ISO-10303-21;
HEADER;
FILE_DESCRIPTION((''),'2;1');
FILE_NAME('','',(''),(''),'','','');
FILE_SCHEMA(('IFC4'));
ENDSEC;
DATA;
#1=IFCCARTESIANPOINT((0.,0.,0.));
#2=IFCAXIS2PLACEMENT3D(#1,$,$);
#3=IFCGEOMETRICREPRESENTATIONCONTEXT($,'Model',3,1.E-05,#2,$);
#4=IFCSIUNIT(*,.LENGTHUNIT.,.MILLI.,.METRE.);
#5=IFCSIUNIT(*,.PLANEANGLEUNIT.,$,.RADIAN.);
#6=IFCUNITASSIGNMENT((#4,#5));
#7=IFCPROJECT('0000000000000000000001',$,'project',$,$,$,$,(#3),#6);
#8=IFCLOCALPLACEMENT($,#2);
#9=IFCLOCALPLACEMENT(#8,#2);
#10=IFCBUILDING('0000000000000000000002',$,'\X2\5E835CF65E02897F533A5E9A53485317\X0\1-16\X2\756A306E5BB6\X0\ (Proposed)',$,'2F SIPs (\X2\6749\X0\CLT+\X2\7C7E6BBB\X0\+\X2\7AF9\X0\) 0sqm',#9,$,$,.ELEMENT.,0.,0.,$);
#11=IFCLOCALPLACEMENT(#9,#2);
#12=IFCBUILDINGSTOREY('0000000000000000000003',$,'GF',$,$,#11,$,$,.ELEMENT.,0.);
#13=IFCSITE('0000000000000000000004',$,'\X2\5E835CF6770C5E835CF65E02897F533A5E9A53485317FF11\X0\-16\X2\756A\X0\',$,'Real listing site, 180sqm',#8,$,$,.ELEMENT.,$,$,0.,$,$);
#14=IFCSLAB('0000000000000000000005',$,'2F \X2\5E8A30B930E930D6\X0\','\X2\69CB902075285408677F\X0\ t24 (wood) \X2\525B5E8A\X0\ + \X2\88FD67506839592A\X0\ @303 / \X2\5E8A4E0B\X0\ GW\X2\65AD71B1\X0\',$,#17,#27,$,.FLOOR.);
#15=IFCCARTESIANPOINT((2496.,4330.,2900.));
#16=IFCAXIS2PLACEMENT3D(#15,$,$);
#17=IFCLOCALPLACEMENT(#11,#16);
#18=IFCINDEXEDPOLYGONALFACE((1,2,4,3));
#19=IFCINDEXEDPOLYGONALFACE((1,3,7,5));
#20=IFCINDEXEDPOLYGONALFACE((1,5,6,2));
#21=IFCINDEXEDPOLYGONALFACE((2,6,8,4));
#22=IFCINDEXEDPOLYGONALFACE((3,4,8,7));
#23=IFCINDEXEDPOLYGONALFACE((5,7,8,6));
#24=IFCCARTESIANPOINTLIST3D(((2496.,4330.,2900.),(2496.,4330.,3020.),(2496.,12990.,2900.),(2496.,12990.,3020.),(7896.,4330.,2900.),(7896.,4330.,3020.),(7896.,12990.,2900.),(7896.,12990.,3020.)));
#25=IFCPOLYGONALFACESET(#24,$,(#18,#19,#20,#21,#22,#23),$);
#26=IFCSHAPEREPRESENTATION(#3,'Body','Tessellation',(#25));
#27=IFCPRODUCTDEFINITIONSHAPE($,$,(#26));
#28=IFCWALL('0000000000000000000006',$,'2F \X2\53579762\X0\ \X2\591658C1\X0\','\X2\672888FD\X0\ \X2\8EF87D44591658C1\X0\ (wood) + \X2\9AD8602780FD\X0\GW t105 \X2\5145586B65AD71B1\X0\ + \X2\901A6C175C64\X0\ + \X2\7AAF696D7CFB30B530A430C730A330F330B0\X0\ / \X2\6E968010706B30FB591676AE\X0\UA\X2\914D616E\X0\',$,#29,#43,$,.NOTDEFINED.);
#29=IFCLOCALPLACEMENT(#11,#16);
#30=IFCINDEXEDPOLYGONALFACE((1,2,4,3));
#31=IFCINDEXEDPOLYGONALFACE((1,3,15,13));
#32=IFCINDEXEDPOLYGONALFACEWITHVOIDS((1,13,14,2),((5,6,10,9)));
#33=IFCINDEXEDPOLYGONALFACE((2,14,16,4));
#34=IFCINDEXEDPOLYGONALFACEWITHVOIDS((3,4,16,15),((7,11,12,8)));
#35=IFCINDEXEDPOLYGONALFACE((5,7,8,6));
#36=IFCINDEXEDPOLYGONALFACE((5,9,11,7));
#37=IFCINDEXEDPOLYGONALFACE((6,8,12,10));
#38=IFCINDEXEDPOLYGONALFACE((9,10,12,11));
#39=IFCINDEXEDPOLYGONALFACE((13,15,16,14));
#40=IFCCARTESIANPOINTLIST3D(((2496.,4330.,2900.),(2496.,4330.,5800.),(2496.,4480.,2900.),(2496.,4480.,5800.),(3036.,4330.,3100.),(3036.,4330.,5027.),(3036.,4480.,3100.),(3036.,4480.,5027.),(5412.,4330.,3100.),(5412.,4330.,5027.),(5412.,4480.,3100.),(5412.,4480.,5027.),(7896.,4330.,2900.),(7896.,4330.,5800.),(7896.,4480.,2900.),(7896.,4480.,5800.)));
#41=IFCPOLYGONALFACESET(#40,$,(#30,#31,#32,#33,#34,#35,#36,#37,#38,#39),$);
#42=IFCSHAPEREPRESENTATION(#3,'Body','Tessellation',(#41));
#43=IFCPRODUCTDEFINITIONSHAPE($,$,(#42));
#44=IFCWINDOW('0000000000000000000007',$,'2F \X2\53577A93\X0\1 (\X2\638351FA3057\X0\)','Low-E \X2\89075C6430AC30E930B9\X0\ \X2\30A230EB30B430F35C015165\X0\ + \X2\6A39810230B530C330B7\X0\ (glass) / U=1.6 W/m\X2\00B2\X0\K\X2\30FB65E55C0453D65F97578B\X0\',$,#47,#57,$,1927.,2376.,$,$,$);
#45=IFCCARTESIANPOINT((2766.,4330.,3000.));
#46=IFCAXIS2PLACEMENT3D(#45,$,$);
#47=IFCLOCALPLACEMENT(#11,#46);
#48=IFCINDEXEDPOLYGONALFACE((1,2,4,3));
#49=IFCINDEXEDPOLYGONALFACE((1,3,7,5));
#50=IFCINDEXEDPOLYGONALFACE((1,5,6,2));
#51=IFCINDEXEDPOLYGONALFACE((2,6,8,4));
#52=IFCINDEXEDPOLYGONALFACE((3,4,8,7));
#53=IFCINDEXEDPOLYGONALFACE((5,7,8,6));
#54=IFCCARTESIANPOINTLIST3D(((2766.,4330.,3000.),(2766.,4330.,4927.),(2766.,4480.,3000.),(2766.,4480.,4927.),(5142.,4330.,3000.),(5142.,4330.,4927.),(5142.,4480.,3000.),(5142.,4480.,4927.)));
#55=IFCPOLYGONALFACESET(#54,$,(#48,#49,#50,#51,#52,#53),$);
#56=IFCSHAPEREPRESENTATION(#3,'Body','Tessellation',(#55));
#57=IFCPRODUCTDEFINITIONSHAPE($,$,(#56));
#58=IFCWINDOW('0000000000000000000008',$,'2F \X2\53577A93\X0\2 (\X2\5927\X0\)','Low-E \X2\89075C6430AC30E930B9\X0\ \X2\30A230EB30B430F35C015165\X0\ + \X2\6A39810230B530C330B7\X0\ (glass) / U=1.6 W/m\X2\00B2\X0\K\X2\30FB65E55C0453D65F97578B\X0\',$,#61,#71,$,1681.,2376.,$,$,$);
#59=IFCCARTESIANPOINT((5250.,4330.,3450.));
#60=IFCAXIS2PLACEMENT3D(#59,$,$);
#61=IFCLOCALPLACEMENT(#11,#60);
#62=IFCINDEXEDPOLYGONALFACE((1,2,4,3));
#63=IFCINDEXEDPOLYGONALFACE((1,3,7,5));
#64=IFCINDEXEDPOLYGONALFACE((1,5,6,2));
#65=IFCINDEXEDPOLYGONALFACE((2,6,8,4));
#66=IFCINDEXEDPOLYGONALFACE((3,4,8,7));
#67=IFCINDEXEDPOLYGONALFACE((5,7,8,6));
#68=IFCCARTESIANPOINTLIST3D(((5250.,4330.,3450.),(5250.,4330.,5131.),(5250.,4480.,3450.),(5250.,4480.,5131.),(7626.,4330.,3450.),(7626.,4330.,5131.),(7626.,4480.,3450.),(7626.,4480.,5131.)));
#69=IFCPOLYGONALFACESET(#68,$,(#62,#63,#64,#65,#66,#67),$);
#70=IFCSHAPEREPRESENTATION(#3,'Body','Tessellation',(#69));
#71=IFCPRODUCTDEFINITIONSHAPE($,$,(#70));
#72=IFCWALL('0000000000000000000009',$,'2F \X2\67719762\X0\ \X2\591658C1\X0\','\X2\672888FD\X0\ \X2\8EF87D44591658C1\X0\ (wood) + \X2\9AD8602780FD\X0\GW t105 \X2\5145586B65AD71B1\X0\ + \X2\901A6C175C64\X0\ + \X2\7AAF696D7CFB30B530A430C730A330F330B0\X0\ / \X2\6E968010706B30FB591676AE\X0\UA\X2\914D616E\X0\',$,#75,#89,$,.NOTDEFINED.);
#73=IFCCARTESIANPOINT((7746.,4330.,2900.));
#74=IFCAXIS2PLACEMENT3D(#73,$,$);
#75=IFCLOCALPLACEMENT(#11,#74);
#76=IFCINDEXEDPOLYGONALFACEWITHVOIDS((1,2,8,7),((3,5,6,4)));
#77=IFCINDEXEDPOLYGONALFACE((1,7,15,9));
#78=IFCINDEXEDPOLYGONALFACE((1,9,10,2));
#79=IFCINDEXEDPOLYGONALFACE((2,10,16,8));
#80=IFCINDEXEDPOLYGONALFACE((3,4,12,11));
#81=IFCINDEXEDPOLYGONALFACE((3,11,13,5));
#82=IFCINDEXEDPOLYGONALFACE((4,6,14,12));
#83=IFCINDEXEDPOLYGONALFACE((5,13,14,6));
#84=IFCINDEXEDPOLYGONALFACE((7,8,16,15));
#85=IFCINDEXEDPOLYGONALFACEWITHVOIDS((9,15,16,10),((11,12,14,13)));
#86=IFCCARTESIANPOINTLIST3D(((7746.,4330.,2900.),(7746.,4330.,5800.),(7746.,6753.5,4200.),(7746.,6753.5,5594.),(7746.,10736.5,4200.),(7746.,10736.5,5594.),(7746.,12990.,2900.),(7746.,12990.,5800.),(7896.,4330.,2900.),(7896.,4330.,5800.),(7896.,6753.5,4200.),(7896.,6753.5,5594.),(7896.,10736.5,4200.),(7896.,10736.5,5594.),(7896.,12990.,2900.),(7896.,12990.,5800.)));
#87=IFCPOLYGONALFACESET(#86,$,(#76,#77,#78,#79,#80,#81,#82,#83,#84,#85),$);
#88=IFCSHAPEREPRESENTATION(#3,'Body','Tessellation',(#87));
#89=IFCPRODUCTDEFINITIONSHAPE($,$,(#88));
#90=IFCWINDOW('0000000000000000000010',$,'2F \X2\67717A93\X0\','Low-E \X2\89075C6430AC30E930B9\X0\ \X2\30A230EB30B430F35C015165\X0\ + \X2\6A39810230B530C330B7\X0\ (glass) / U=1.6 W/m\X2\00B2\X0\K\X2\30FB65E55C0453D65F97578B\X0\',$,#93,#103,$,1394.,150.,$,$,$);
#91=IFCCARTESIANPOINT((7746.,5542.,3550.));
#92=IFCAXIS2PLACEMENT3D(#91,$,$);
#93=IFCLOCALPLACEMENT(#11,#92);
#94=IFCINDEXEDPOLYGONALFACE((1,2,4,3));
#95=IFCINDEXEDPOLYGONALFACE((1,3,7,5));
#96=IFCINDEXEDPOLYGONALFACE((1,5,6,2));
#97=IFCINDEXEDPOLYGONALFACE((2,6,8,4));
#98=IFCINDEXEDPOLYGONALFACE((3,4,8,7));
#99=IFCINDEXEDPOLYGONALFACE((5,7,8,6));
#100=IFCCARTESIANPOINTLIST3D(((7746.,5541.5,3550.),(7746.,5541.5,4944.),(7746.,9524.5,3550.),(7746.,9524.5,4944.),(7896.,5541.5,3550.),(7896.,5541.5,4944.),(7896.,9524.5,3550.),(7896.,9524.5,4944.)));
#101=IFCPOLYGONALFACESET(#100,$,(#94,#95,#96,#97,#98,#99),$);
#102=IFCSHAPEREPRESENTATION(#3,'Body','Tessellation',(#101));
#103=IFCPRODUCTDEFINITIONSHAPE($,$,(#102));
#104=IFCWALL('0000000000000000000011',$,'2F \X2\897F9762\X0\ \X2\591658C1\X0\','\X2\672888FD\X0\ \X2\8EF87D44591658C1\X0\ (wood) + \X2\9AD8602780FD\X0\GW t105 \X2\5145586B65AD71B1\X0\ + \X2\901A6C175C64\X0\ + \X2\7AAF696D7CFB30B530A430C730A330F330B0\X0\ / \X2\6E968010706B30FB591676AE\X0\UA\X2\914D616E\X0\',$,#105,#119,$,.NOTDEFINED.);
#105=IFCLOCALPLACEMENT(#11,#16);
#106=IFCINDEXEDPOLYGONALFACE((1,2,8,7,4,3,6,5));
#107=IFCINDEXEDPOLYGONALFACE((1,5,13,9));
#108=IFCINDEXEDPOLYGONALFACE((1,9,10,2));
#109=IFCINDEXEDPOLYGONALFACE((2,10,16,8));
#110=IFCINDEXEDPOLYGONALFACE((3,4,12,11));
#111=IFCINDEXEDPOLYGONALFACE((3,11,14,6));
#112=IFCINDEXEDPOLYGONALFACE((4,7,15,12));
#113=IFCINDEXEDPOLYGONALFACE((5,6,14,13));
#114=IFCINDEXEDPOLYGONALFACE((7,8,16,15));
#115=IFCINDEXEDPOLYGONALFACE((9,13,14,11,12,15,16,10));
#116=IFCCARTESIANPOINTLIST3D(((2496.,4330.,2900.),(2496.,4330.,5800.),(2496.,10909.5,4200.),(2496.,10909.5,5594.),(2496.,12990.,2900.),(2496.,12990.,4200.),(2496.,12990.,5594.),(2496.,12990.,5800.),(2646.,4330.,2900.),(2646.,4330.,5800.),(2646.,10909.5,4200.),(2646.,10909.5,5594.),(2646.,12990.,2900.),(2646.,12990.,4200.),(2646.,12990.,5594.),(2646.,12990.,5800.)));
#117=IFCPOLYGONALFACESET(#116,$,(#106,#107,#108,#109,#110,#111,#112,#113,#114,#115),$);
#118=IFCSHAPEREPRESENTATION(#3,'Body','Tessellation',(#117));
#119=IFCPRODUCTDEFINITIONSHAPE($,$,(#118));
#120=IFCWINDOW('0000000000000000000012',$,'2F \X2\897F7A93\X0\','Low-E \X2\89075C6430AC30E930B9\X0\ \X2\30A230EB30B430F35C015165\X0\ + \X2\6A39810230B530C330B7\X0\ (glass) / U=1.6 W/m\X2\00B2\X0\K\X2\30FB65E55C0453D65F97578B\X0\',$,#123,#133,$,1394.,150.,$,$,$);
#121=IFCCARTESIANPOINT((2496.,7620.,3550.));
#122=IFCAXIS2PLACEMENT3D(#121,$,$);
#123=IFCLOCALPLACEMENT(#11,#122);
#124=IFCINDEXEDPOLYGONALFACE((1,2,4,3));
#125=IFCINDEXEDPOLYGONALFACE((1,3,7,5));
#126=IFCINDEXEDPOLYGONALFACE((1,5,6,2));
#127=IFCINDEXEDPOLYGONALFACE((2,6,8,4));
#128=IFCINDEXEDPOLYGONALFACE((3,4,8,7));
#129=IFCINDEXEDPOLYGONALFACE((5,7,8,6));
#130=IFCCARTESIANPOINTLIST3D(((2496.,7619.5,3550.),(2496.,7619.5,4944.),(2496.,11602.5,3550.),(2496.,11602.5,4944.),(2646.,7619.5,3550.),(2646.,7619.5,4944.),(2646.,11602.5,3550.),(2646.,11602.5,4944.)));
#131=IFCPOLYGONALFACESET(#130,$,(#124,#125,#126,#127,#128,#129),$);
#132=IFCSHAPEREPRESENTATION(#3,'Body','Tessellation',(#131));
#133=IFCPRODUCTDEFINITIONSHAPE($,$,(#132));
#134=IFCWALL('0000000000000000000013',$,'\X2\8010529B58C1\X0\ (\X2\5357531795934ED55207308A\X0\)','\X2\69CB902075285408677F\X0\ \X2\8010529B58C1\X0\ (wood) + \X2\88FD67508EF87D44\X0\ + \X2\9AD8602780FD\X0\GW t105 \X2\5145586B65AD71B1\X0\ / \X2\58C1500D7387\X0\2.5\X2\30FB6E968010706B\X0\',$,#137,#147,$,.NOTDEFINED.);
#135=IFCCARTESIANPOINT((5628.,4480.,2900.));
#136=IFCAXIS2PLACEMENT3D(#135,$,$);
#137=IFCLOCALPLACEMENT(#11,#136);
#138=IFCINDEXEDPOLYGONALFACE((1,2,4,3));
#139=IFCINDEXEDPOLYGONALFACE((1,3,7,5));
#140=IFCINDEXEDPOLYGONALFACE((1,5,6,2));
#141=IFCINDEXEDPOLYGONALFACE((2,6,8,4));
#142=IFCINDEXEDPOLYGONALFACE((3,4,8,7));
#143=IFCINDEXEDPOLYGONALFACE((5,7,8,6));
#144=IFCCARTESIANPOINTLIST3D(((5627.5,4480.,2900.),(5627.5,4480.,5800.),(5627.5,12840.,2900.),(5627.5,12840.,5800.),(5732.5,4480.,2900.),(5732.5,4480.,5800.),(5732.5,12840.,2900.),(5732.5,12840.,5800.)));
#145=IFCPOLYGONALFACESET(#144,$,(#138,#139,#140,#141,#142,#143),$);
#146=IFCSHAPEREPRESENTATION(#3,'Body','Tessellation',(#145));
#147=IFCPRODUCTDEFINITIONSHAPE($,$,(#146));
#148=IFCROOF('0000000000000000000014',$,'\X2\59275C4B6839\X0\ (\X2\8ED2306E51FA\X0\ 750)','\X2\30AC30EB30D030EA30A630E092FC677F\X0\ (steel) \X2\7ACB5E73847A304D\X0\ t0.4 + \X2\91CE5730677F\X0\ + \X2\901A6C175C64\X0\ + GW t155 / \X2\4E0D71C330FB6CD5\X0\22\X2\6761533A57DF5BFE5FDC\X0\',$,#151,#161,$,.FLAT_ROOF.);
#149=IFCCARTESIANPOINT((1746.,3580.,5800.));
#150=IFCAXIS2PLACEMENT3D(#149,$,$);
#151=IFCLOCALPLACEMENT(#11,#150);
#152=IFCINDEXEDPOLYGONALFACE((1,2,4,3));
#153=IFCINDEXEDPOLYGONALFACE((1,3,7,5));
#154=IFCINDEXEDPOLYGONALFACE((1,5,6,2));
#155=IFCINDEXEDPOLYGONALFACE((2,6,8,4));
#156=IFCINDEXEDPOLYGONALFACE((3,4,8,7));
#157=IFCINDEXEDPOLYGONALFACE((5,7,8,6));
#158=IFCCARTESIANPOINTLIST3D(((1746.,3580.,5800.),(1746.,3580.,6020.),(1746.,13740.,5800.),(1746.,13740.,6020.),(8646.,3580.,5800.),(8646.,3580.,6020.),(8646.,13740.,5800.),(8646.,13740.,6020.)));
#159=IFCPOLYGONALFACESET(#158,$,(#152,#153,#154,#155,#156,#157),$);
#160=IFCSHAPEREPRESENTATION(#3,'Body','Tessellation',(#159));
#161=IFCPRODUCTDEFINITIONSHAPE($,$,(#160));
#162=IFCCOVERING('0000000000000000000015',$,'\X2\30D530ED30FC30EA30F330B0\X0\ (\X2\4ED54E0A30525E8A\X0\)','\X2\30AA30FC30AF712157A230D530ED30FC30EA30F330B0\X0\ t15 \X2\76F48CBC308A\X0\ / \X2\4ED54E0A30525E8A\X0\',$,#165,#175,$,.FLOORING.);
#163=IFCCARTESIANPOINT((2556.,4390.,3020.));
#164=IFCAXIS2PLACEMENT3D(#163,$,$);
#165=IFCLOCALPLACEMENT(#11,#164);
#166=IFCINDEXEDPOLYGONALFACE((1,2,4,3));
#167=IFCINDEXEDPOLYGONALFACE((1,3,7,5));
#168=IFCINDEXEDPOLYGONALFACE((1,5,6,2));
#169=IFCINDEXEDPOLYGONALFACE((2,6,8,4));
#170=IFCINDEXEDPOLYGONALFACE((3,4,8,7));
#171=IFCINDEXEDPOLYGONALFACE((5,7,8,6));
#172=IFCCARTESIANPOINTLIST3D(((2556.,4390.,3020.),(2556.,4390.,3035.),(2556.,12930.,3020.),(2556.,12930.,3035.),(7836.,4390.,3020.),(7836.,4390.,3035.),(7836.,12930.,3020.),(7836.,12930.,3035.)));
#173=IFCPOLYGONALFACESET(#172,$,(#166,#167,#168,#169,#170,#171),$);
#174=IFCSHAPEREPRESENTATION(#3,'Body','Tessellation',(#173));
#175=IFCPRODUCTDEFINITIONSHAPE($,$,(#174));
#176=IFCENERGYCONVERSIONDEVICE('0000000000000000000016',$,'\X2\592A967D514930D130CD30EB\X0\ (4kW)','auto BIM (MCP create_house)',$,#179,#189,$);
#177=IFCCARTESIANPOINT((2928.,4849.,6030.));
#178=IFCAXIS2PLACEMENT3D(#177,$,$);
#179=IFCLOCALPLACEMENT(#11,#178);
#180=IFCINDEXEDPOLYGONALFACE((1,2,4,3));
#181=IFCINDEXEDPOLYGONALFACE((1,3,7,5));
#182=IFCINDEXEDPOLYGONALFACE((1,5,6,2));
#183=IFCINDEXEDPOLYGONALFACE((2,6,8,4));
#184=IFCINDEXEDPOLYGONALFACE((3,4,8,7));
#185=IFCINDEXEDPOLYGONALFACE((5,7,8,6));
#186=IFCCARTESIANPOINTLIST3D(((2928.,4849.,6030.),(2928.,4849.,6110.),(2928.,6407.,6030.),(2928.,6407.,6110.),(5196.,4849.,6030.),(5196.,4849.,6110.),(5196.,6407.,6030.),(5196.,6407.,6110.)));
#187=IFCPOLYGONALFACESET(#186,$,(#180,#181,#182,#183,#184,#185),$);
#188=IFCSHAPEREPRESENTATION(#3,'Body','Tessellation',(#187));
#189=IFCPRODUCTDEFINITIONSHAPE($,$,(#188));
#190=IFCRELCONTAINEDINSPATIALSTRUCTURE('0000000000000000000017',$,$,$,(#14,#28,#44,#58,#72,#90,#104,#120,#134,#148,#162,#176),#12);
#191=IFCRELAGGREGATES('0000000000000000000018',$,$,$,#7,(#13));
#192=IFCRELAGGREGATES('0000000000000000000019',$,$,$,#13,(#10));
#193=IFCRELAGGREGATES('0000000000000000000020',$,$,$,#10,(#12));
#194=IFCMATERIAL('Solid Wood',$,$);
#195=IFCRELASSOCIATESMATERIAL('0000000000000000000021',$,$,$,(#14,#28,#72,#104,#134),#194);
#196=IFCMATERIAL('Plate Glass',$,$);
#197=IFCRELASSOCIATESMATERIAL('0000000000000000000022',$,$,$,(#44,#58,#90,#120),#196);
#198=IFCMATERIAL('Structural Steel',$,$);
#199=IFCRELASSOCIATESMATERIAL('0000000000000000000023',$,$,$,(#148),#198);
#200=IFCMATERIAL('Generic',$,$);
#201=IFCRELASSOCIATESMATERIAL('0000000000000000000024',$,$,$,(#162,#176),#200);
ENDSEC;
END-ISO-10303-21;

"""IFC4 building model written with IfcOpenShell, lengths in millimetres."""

from ifc_helpers import new_model, si_unit, frame, frame_2d, origin, place, context, project, spatial, rectangle, extrude, material, element, fill, save


model = new_model("IFC4")

# Units and contexts
model_context = context("Model", 3, precision=1e-05, world=origin())
ifc_project = project(units=[si_unit("LENGTHUNIT", "METRE", prefix="MILLI"), si_unit("PLANEANGLEUNIT", "RADIAN")], contexts=[model_context])

# Site, building, storey
site_placement = place(None, origin())
site = spatial("IfcSite", under=ifc_project, at=site_placement, Name="広島県広島市西区庚午北１-16番", ObjectType="Real listing site, 180sqm", CompositionType="ELEMENT", RefElevation=0.0)
building_placement = place(site_placement, origin())
building = spatial("IfcBuilding", under=site, at=building_placement, Name="広島市西区庚午北1-16番の家 (Proposed)", ObjectType="2F SIPs (杉CLT+籾殻+竹) 0sqm", CompositionType="ELEMENT", ElevationOfRefHeight=0.0, ElevationOfTerrain=0.0)
storey_placement = place(building_placement, origin())
storey = spatial("IfcBuildingStorey", under=building, at=storey_placement, Name="GF", CompositionType="ELEMENT", Elevation=0.0)

# Slab
ifc_material_1 = material(Name="Solid Wood")
slab_placement = place(storey_placement, frame((2496.0, 4330.0, 2900.0)))
element("IfcSlab", 1, at=slab_placement, inside=storey, material=ifc_material_1, Name="2F 床スラブ", Description="構造用合板 t24 (wood) 剛床 + 製材根太 @303 / 床下 GW断熱", PredefinedType="FLOOR", context=model_context, shape_type="SweptSolid", body=[
    extrude(rectangle(XDim=5400.0, YDim=8660.0, at=frame_2d((2700.0, 4330.0))), frame((2496.0, 4330.0, 2900.0)), (0.0, 0.0, 1.0), 120.0),
])

# Wall, openings, windows
wall_1_placement = place(storey_placement, frame((2496.0, 4330.0, 2900.0)))
wall_1 = element("IfcWall", 2, at=wall_1_placement, inside=storey, material=ifc_material_1, Name="2F 南面 外壁", Description="木製 軸組外壁 (wood) + 高性能GW t105 充填断熱 + 通気層 + 窯業系サイディング / 準耐火・外皮UA配慮", PredefinedType="NOTDEFINED", context=model_context, shape_type="SweptSolid", body=[
    extrude(rectangle(XDim=5400.0, YDim=150.0, at=frame_2d((2700.0, 75.0))), frame((2496.0, 4330.0, 2900.0)), (0.0, 0.0, 1.0), 2900.0),
])
opening_1_placement = place(storey_placement, frame((2766.0, 4330.0, 3000.0)))
opening_1 = element("IfcOpeningElement", 3, at=opening_1_placement, cuts=wall_1, PredefinedType="NOTDEFINED", context=model_context, shape_type="SweptSolid", body=[
    extrude(rectangle(XDim=2376.0, YDim=150.0, at=frame_2d((1188.0, 75.0))), frame((2766.0, 4330.0, 3000.0)), (0.0, 0.0, 1.0), 1927.0),
])
opening_2_placement = place(storey_placement, frame((5250.0, 4330.0, 3450.0)))
opening_2 = element("IfcOpeningElement", 4, at=opening_2_placement, cuts=wall_1, PredefinedType="NOTDEFINED", context=model_context, shape_type="SweptSolid", body=[
    extrude(rectangle(XDim=2376.0, YDim=150.0, at=frame_2d((1188.0, 75.0))), frame((5250.0, 4330.0, 3450.0)), (0.0, 0.0, 1.0), 1681.0),
])
ifc_material_2 = material(Name="Plate Glass")
window_1_placement = place(storey_placement, frame((2766.0, 4330.0, 3000.0)))
window_1 = element("IfcWindow", 5, at=window_1_placement, inside=storey, material=ifc_material_2, Name="2F 南窓1 (掃出し)", Description="Low-E 複層ガラス アルゴン封入 + 樹脂サッシ (glass) / U=1.6 W/m²K・日射取得型", OverallHeight=1927.0, OverallWidth=2376.0, context=model_context, shape_type="SweptSolid", body=[
    extrude(rectangle(XDim=2376.0, YDim=150.0, at=frame_2d((1188.0, 75.0))), frame((2766.0, 4330.0, 3000.0)), (0.0, 0.0, 1.0), 1927.0),
])
fill(opening_1, window_1)
window_2_placement = place(storey_placement, frame((5250.0, 4330.0, 3450.0)))
window_2 = element("IfcWindow", 6, at=window_2_placement, inside=storey, material=ifc_material_2, Name="2F 南窓2 (大)", Description="Low-E 複層ガラス アルゴン封入 + 樹脂サッシ (glass) / U=1.6 W/m²K・日射取得型", OverallHeight=1681.0, OverallWidth=2376.0, context=model_context, shape_type="SweptSolid", body=[
    extrude(rectangle(XDim=2376.0, YDim=150.0, at=frame_2d((1188.0, 75.0))), frame((5250.0, 4330.0, 3450.0)), (0.0, 0.0, 1.0), 1681.0),
])
fill(opening_2, window_2)

# Walls, openings, windows
wall_2_placement = place(storey_placement, frame((7746.0, 4330.0, 2900.0)))
wall_2 = element("IfcWall", 7, at=wall_2_placement, inside=storey, material=ifc_material_1, Name="2F 東面 外壁", Description="木製 軸組外壁 (wood) + 高性能GW t105 充填断熱 + 通気層 + 窯業系サイディング / 準耐火・外皮UA配慮", PredefinedType="NOTDEFINED", context=model_context, shape_type="SweptSolid", body=[
    extrude(rectangle(XDim=150.0, YDim=8660.0, at=frame_2d((75.0, 4330.0))), frame((7746.0, 4330.0, 2900.0)), (0.0, 0.0, 1.0), 2900.0),
])
opening_3_placement = place(storey_placement, frame((7746.0, 5542.0, 3550.0)))
opening_3 = element("IfcOpeningElement", 8, at=opening_3_placement, cuts=wall_2, PredefinedType="NOTDEFINED", context=model_context, shape_type="SweptSolid", body=[
    extrude(rectangle(XDim=150.0, YDim=3983.0, at=frame_2d((75.0, 1991.0))), frame((7746.0, 5542.0, 3550.0)), (0.0, 0.0, 1.0), 1394.0),
])
window_3_placement = place(storey_placement, frame((7746.0, 5542.0, 3550.0)))
window_3 = element("IfcWindow", 9, at=window_3_placement, inside=storey, material=ifc_material_2, Name="2F 東窓", Description="Low-E 複層ガラス アルゴン封入 + 樹脂サッシ (glass) / U=1.6 W/m²K・日射取得型", OverallHeight=1394.0, OverallWidth=150.0, context=model_context, shape_type="SweptSolid", body=[
    extrude(rectangle(XDim=150.0, YDim=3983.0, at=frame_2d((75.0, 1991.0))), frame((7746.0, 5542.0, 3550.0)), (0.0, 0.0, 1.0), 1394.0),
])
fill(opening_3, window_3)
wall_3_placement = place(storey_placement, frame((2496.0, 4330.0, 2900.0)))
wall_3 = element("IfcWall", 10, at=wall_3_placement, inside=storey, material=ifc_material_1, Name="2F 西面 外壁", Description="木製 軸組外壁 (wood) + 高性能GW t105 充填断熱 + 通気層 + 窯業系サイディング / 準耐火・外皮UA配慮", PredefinedType="NOTDEFINED", context=model_context, shape_type="SweptSolid", body=[
    extrude(rectangle(XDim=150.0, YDim=8660.0, at=frame_2d((75.0, 4330.0))), frame((2496.0, 4330.0, 2900.0)), (0.0, 0.0, 1.0), 2900.0),
])
opening_4_placement = place(storey_placement, frame((2496.0, 7620.0, 3550.0)))
opening_4 = element("IfcOpeningElement", 11, at=opening_4_placement, cuts=wall_3, PredefinedType="NOTDEFINED", context=model_context, shape_type="SweptSolid", body=[
    extrude(rectangle(XDim=150.0, YDim=3983.0, at=frame_2d((75.0, 1991.0))), frame((2496.0, 7620.0, 3550.0)), (0.0, 0.0, 1.0), 1394.0),
])
window_4_placement = place(storey_placement, frame((2496.0, 7620.0, 3550.0)))
window_4 = element("IfcWindow", 12, at=window_4_placement, inside=storey, material=ifc_material_2, Name="2F 西窓", Description="Low-E 複層ガラス アルゴン封入 + 樹脂サッシ (glass) / U=1.6 W/m²K・日射取得型", OverallHeight=1394.0, OverallWidth=150.0, context=model_context, shape_type="SweptSolid", body=[
    extrude(rectangle(XDim=150.0, YDim=3983.0, at=frame_2d((75.0, 1991.0))), frame((2496.0, 7620.0, 3550.0)), (0.0, 0.0, 1.0), 1394.0),
])
fill(opening_4, window_4)

# Wall
wall_4_placement = place(storey_placement, frame((5628.0, 4480.0, 2900.0)))
element("IfcWall", 13, at=wall_4_placement, inside=storey, material=ifc_material_1, Name="耐力壁 (南北間仕切り)", Description="構造用合板 耐力壁 (wood) + 製材軸組 + 高性能GW t105 充填断熱 / 壁倍率2.5・準耐火", PredefinedType="NOTDEFINED", context=model_context, shape_type="SweptSolid", body=[
    extrude(rectangle(XDim=105.0, YDim=8360.0, at=frame_2d((52.0, 4180.0))), frame((5628.0, 4480.0, 2900.0)), (0.0, 0.0, 1.0), 2900.0),
])

# Roof
ifc_material_3 = material(Name="Structural Steel")
roof_placement = place(storey_placement, frame((1746.0, 3580.0, 5800.0)))
element("IfcRoof", 14, at=roof_placement, inside=storey, material=ifc_material_3, Name="大屋根 (軒の出 750)", Description="ガルバリウム鋼板 (steel) 立平葺き t0.4 + 野地板 + 通気層 + GW t155 / 不燃・法22条区域対応", PredefinedType="FLAT_ROOF", context=model_context, shape_type="SweptSolid", body=[
    extrude(rectangle(XDim=6900.0, YDim=10160.0, at=frame_2d((3450.0, 5080.0))), frame((1746.0, 3580.0, 5800.0)), (0.0, 0.0, 1.0), 220.0),
])

# Covering
ifc_material_4 = material(Name="Generic")
covering_placement = place(storey_placement, frame((2556.0, 4390.0, 3020.0)))
element("IfcCovering", 15, at=covering_placement, inside=storey, material=ifc_material_4, Name="フローリング (仕上げ床)", Description="オーク無垢フローリング t15 直貼り / 仕上げ床", PredefinedType="FLOORING", context=model_context, shape_type="SweptSolid", body=[
    extrude(rectangle(XDim=5280.0, YDim=8540.0, at=frame_2d((2640.0, 4270.0))), frame((2556.0, 4390.0, 3020.0)), (0.0, 0.0, 1.0), 15.0),
])

# Energy conversion device
energy_conversion_device_placement = place(storey_placement, frame((2928.0, 4849.0, 6030.0)))
element("IfcEnergyConversionDevice", 16, at=energy_conversion_device_placement, inside=storey, material=ifc_material_4, Name="太陽光パネル (4kW)", Description="auto BIM (MCP create_house)", context=model_context, shape_type="SweptSolid", body=[
    extrude(rectangle(XDim=2268.0, YDim=1558.0, at=frame_2d((1134.0, 779.0))), frame((2928.0, 4849.0, 6030.0)), (0.0, 0.0, 1.0), 80.0),
])

save(model, "model.ifc")
